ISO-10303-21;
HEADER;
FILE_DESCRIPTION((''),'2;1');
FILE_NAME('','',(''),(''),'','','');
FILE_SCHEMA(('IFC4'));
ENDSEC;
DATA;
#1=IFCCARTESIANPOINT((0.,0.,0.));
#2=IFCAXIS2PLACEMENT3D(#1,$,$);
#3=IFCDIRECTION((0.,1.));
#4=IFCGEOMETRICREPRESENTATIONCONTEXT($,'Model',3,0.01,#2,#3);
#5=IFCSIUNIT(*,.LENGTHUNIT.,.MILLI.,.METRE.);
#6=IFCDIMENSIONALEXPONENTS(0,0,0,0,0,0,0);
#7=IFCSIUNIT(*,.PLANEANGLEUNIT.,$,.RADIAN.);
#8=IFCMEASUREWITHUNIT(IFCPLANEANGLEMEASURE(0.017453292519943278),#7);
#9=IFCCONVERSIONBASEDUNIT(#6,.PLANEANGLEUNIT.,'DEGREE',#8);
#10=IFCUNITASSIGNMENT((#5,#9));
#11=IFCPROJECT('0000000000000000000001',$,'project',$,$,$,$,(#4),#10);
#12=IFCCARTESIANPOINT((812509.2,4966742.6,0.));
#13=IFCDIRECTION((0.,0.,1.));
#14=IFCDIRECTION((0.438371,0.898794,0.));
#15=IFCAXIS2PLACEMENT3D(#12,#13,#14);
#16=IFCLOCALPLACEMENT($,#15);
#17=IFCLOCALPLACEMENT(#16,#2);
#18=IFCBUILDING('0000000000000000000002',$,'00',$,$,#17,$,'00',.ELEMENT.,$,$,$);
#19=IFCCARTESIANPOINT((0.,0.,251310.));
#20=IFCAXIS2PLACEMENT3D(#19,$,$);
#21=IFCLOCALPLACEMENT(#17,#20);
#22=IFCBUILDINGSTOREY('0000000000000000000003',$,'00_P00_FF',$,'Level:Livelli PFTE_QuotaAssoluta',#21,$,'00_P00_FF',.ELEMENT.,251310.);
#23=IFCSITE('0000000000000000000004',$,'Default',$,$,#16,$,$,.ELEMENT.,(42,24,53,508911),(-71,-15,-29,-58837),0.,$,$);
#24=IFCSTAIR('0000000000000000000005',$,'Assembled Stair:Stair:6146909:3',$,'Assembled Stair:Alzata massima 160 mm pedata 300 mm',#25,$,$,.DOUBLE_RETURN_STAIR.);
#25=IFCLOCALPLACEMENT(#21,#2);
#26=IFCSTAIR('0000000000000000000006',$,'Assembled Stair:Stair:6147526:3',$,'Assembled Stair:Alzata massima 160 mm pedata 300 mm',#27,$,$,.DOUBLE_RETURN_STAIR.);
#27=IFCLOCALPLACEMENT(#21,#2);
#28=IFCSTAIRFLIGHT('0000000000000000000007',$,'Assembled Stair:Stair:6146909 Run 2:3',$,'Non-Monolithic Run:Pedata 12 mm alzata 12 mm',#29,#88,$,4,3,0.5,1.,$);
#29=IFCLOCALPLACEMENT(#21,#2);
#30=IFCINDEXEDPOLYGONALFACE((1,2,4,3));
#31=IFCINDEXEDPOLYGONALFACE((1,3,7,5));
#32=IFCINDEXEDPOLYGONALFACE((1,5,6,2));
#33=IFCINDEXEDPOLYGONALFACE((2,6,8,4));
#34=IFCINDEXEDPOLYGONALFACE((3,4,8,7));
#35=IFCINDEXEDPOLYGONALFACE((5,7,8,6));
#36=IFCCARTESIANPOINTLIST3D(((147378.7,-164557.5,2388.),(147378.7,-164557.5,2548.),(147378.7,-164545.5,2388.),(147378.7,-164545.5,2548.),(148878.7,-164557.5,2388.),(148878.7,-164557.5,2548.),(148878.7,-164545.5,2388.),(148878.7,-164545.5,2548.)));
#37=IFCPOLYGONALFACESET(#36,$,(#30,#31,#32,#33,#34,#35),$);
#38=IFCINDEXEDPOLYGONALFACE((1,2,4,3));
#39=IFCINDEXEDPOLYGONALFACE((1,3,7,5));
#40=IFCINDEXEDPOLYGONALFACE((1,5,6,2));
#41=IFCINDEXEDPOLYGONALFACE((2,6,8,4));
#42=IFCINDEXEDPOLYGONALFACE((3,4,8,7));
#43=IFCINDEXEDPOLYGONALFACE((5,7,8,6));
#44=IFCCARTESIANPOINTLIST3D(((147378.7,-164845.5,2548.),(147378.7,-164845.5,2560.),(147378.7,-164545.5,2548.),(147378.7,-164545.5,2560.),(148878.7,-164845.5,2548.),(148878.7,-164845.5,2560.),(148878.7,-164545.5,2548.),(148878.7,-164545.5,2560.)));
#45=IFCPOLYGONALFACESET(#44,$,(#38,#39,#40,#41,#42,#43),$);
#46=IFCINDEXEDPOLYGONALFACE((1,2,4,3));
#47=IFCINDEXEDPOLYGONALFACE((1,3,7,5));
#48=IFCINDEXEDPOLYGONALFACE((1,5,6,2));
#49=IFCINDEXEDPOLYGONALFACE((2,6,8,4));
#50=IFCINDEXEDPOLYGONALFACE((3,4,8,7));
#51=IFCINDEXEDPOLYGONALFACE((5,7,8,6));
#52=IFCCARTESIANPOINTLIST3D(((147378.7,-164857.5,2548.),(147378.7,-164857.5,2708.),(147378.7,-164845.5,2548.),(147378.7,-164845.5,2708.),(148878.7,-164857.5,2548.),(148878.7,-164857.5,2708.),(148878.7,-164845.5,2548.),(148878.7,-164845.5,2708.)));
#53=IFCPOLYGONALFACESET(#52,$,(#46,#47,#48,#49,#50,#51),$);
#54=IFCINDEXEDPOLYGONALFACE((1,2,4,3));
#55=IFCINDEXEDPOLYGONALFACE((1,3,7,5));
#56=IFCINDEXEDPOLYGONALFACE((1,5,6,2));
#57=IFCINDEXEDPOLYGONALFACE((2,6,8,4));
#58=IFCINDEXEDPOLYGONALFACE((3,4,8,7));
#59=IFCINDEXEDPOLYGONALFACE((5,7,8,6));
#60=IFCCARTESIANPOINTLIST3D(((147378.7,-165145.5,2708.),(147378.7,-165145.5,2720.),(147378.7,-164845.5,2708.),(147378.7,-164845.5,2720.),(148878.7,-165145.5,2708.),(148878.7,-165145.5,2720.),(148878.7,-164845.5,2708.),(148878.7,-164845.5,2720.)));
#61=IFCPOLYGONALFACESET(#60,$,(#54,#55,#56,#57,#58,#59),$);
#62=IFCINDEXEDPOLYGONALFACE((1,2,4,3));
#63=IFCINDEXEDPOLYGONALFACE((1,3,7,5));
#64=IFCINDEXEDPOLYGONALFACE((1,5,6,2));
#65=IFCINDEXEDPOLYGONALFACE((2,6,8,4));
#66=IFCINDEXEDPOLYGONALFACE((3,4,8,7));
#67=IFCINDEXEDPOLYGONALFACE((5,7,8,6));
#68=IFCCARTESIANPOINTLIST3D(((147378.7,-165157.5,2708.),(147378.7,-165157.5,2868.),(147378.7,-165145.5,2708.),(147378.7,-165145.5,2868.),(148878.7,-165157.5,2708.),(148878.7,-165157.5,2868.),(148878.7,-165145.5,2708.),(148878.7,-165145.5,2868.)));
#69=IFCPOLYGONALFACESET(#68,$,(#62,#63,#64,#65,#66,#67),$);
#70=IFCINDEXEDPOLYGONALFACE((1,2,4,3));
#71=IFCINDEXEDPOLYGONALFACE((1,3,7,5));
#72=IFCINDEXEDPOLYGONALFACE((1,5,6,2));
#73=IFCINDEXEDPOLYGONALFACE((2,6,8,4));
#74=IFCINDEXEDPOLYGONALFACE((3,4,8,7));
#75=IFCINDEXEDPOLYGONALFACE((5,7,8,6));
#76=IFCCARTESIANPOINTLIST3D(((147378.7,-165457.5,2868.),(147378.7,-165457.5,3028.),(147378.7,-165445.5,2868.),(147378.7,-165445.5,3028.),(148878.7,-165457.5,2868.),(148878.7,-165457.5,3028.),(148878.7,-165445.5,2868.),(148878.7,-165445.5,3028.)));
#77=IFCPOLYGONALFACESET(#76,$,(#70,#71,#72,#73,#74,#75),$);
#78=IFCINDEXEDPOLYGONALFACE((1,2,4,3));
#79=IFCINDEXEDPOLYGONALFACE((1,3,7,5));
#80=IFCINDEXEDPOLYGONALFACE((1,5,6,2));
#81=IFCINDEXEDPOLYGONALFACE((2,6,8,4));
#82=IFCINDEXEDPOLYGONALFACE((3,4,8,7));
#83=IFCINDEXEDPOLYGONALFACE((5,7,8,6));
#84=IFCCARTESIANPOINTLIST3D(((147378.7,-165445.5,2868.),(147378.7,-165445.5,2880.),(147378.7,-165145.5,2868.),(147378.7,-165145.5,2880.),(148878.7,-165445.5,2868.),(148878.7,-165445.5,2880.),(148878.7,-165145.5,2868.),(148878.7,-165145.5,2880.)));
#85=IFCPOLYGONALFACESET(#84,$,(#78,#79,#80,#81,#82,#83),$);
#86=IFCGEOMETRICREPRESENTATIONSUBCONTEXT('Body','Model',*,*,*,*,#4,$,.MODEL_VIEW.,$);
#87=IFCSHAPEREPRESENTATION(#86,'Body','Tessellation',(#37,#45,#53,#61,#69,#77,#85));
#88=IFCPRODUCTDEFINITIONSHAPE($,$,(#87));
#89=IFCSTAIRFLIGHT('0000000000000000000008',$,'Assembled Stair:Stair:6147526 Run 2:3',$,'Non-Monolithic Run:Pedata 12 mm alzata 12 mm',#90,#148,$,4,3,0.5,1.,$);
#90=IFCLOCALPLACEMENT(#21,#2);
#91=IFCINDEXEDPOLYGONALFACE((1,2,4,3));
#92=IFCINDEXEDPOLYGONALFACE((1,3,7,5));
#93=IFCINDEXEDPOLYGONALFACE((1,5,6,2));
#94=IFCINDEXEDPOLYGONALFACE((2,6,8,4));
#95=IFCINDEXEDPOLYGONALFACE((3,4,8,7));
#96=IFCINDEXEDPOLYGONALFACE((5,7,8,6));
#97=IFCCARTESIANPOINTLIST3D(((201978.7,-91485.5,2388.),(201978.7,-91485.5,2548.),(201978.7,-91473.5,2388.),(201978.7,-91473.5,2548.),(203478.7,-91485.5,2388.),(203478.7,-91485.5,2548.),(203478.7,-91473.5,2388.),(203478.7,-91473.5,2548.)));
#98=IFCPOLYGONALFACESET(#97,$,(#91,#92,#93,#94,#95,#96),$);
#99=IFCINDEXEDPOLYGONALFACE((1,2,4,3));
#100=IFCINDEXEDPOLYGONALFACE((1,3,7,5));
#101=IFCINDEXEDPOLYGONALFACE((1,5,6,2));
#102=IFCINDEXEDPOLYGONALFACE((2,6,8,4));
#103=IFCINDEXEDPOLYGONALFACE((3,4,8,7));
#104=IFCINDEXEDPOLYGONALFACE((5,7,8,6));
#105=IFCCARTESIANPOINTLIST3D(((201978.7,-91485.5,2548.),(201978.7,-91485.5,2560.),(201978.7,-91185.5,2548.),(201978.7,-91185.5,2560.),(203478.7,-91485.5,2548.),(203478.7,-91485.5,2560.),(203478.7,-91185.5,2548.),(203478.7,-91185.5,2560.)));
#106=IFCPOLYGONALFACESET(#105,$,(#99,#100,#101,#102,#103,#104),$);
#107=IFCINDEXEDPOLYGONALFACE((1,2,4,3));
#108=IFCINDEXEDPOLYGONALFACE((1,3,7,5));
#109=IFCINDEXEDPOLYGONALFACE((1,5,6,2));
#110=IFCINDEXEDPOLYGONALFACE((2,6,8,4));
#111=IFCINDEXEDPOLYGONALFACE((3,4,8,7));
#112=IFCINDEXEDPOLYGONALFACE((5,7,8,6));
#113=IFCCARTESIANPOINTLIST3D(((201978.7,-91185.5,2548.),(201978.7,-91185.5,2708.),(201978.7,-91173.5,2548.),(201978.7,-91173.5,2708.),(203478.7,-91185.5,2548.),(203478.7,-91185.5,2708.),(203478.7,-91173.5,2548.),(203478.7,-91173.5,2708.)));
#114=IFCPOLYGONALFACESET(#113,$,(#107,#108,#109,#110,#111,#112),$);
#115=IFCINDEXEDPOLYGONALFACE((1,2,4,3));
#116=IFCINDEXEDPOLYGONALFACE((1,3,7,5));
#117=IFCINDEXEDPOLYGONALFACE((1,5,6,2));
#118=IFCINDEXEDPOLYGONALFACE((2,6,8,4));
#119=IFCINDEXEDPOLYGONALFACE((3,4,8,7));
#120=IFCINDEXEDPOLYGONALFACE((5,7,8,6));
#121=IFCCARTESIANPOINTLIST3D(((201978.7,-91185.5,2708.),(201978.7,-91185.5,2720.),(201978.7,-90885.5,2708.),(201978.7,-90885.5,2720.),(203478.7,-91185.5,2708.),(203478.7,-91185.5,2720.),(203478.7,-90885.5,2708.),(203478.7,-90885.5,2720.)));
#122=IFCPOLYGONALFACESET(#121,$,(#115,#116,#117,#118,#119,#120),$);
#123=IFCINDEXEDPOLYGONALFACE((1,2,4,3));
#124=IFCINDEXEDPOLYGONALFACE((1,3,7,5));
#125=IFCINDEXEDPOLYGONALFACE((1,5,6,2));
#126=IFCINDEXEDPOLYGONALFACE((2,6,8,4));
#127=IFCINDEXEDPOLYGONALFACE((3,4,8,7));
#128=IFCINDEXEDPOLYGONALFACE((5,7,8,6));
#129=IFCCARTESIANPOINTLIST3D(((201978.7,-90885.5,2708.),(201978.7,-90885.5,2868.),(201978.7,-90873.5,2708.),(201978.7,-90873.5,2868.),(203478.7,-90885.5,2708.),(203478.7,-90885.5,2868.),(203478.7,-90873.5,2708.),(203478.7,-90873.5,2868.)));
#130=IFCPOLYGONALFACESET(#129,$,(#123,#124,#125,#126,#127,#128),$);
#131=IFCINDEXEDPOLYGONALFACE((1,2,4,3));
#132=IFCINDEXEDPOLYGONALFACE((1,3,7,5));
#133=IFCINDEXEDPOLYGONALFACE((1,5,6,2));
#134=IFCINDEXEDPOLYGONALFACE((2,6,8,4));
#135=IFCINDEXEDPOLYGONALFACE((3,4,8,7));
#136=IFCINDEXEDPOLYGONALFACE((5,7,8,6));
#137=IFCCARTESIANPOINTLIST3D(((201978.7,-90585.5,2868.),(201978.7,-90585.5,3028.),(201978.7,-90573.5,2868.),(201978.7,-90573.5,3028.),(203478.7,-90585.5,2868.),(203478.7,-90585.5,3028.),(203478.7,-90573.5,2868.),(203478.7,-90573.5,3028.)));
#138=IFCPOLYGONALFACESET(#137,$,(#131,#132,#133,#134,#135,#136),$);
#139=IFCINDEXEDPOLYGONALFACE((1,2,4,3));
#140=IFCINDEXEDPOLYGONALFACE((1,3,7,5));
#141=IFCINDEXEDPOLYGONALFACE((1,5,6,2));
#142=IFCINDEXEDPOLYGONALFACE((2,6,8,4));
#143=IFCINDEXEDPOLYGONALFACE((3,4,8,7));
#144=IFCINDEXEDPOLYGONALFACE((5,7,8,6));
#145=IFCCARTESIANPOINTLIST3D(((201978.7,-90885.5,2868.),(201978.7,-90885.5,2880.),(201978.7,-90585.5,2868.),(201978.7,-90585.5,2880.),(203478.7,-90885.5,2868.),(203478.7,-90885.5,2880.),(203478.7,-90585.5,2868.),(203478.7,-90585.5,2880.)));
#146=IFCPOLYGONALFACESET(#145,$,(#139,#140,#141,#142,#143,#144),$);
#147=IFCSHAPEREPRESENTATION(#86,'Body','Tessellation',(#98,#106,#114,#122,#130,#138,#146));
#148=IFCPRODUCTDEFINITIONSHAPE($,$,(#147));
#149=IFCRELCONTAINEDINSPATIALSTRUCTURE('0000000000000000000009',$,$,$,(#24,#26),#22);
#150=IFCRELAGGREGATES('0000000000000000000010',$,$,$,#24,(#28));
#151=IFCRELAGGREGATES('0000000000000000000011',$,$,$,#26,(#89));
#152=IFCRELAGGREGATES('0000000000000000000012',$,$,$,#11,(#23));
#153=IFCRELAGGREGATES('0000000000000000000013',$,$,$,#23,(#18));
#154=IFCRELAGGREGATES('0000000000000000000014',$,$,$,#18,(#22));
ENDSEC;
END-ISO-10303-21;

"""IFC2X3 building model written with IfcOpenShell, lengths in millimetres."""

from ifc_helpers import new_model, entity, si_unit, converted_unit, direction, frame, frame_2d, origin, origin_2d_with_axis, place, context, subcontext, project, spatial, rectangle, extrude, element, aggregate, save


model = new_model("IFC2X3")

# Units and contexts
model_context = context("Model", 3, precision=0.01, world=origin(), true_north=direction((0.0, 1.0)))
body_context = subcontext(model_context, "Body", "Model", "MODEL_VIEW")
ifc_project = project(units=[si_unit("LENGTHUNIT", "METRE", prefix="MILLI"), converted_unit("PLANEANGLEUNIT", "DEGREE", entity("IfcPlaneAngleMeasure", 0.017453292519943278), si_unit("PLANEANGLEUNIT", "RADIAN"), dimensions=[0, 0, 0, 0, 0, 0, 0])], contexts=[model_context])

# Site, building, storey
site_placement = place(None, frame((812509.2, 4966742.6, 0.0), z_axis=(0.0, 0.0, 1.0), x_axis=(0.438371, 0.898794, 0.0)))
site = spatial("IfcSite", under=ifc_project, at=site_placement, Name="Default", CompositionType="ELEMENT", RefLatitude=(42, 24, 53, 508911), RefLongitude=(-71, -15, -29, -58837), RefElevation=0.0)
building_placement = place(site_placement, origin())
building = spatial("IfcBuilding", under=site, at=building_placement, Name="00", LongName="00", CompositionType="ELEMENT")
storey_placement = place(building_placement, frame((0.0, 0.0, 251310.0)))
storey = spatial("IfcBuildingStorey", under=building, at=storey_placement, Name="00_P00_FF", ObjectType="Level:Livelli PFTE_QuotaAssoluta", LongName="00_P00_FF", CompositionType="ELEMENT", Elevation=251310.0)

# Stairs
stair_1_placement = place(storey_placement, origin())
stair_1 = element("IfcStair", 1, at=stair_1_placement, inside=storey, Name="Assembled Stair:Stair:6146909:3", ObjectType="Assembled Stair:Alzata massima 160 mm pedata 300 mm", ShapeType="DOUBLE_RETURN_STAIR")
stair_2_placement = place(storey_placement, origin())
stair_2 = element("IfcStair", 2, at=stair_2_placement, inside=storey, Name="Assembled Stair:Stair:6147526:3", ObjectType="Assembled Stair:Alzata massima 160 mm pedata 300 mm", ShapeType="DOUBLE_RETURN_STAIR")

# Stair flights
stair_flight_1_placement = place(stair_1_placement, origin())
stair_flight_1 = element("IfcStairFlight", 3, at=stair_flight_1_placement, Name="Assembled Stair:Stair:6146909 Run 2:3", ObjectType="Non-Monolithic Run:Pedata 12 mm alzata 12 mm", NumberOfRiser=4, NumberOfTreads=3, RiserHeight=0.5, TreadLength=1.0, context=body_context, shape_type="SweptSolid", body=[
    extrude(rectangle(XDim=1500.0, YDim=12.0, at=origin_2d_with_axis()), frame((148128.7, -164551.5, 2388.0)), (0.0, 0.0, 1.0), 160.0),
    extrude(rectangle(XDim=300.0, YDim=1500.0, at=origin_2d_with_axis()), frame((148128.7, -164695.5, 2548.0), z_axis=(0.0, 0.0, 1.0), x_axis=(0.0, 1.0, 0.0)), (0.0, 0.0, 1.0), 12.0),
    extrude(rectangle(XDim=1500.0, YDim=12.0, at=origin_2d_with_axis()), frame((148128.7, -164851.5, 2548.0)), (0.0, 0.0, 1.0), 160.0),
    extrude(rectangle(XDim=300.0, YDim=1500.0, at=frame_2d((0.0, 0.0), x_axis=(1.0, 0.0))), frame((148128.7, -164995.5, 2708.0), z_axis=(0.0, 0.0, 1.0), x_axis=(0.0, 1.0, 0.0)), (0.0, 0.0, 1.0), 12.0),
    extrude(rectangle(XDim=1500.0, YDim=12.0, at=origin_2d_with_axis()), frame((148128.7, -165151.5, 2708.0)), (0.0, 0.0, 1.0), 160.0),
    extrude(rectangle(XDim=1500.0, YDim=12.0, at=origin_2d_with_axis()), frame((148128.7, -165451.5, 2868.0)), (0.0, 0.0, 1.0), 160.0),
    extrude(rectangle(XDim=300.0, YDim=1500.0, at=frame_2d((0.0, 0.0), x_axis=(1.0, 0.0))), frame((148128.7, -165295.5, 2868.0), z_axis=(0.0, 0.0, 1.0), x_axis=(0.0, 1.0, 0.0)), (0.0, 0.0, 1.0), 12.0),
])
aggregate(stair_1, [stair_flight_1])
stair_flight_2_placement = place(stair_2_placement, origin())
stair_flight_2 = element("IfcStairFlight", 4, at=stair_flight_2_placement, Name="Assembled Stair:Stair:6147526 Run 2:3", ObjectType="Non-Monolithic Run:Pedata 12 mm alzata 12 mm", NumberOfRiser=4, NumberOfTreads=3, RiserHeight=0.5, TreadLength=1.0, context=body_context, shape_type="SweptSolid", body=[
    extrude(rectangle(XDim=1500.0, YDim=12.0, at=origin_2d_with_axis()), frame((202728.7, -91479.5, 2388.0), z_axis=(0.0, 0.0, 1.0), x_axis=(-1.0, 0.0, 0.0)), (0.0, 0.0, 1.0), 160.0),
    extrude(rectangle(XDim=300.0, YDim=1500.0, at=origin_2d_with_axis()), frame((202728.7, -91335.5, 2548.0), z_axis=(0.0, 0.0, 1.0), x_axis=(0.0, -1.0, 0.0)), (0.0, 0.0, 1.0), 12.0),
    extrude(rectangle(XDim=1500.0, YDim=12.0, at=origin_2d_with_axis()), frame((202728.7, -91179.5, 2548.0), z_axis=(0.0, 0.0, 1.0), x_axis=(-1.0, 0.0, 0.0)), (0.0, 0.0, 1.0), 160.0),
    extrude(rectangle(XDim=300.0, YDim=1500.0, at=frame_2d((0.0, 0.0), x_axis=(1.0, 0.0))), frame((202728.7, -91035.5, 2708.0), z_axis=(0.0, 0.0, 1.0), x_axis=(0.0, -1.0, 0.0)), (0.0, 0.0, 1.0), 12.0),
    extrude(rectangle(XDim=1500.0, YDim=12.0, at=origin_2d_with_axis()), frame((202728.7, -90879.5, 2708.0), z_axis=(0.0, 0.0, 1.0), x_axis=(-1.0, 0.0, 0.0)), (0.0, 0.0, 1.0), 160.0),
    extrude(rectangle(XDim=1500.0, YDim=12.0, at=origin_2d_with_axis()), frame((202728.7, -90579.5, 2868.0), z_axis=(0.0, 0.0, 1.0), x_axis=(-1.0, 0.0, 0.0)), (0.0, 0.0, 1.0), 160.0),
    extrude(rectangle(XDim=300.0, YDim=1500.0, at=frame_2d((0.0, 0.0), x_axis=(1.0, 0.0))), frame((202728.7, -90735.5, 2868.0), z_axis=(0.0, 0.0, 1.0), x_axis=(0.0, -1.0, 0.0)), (0.0, 0.0, 1.0), 12.0),
])
aggregate(stair_2, [stair_flight_2])

save(model, "model.ifc")
